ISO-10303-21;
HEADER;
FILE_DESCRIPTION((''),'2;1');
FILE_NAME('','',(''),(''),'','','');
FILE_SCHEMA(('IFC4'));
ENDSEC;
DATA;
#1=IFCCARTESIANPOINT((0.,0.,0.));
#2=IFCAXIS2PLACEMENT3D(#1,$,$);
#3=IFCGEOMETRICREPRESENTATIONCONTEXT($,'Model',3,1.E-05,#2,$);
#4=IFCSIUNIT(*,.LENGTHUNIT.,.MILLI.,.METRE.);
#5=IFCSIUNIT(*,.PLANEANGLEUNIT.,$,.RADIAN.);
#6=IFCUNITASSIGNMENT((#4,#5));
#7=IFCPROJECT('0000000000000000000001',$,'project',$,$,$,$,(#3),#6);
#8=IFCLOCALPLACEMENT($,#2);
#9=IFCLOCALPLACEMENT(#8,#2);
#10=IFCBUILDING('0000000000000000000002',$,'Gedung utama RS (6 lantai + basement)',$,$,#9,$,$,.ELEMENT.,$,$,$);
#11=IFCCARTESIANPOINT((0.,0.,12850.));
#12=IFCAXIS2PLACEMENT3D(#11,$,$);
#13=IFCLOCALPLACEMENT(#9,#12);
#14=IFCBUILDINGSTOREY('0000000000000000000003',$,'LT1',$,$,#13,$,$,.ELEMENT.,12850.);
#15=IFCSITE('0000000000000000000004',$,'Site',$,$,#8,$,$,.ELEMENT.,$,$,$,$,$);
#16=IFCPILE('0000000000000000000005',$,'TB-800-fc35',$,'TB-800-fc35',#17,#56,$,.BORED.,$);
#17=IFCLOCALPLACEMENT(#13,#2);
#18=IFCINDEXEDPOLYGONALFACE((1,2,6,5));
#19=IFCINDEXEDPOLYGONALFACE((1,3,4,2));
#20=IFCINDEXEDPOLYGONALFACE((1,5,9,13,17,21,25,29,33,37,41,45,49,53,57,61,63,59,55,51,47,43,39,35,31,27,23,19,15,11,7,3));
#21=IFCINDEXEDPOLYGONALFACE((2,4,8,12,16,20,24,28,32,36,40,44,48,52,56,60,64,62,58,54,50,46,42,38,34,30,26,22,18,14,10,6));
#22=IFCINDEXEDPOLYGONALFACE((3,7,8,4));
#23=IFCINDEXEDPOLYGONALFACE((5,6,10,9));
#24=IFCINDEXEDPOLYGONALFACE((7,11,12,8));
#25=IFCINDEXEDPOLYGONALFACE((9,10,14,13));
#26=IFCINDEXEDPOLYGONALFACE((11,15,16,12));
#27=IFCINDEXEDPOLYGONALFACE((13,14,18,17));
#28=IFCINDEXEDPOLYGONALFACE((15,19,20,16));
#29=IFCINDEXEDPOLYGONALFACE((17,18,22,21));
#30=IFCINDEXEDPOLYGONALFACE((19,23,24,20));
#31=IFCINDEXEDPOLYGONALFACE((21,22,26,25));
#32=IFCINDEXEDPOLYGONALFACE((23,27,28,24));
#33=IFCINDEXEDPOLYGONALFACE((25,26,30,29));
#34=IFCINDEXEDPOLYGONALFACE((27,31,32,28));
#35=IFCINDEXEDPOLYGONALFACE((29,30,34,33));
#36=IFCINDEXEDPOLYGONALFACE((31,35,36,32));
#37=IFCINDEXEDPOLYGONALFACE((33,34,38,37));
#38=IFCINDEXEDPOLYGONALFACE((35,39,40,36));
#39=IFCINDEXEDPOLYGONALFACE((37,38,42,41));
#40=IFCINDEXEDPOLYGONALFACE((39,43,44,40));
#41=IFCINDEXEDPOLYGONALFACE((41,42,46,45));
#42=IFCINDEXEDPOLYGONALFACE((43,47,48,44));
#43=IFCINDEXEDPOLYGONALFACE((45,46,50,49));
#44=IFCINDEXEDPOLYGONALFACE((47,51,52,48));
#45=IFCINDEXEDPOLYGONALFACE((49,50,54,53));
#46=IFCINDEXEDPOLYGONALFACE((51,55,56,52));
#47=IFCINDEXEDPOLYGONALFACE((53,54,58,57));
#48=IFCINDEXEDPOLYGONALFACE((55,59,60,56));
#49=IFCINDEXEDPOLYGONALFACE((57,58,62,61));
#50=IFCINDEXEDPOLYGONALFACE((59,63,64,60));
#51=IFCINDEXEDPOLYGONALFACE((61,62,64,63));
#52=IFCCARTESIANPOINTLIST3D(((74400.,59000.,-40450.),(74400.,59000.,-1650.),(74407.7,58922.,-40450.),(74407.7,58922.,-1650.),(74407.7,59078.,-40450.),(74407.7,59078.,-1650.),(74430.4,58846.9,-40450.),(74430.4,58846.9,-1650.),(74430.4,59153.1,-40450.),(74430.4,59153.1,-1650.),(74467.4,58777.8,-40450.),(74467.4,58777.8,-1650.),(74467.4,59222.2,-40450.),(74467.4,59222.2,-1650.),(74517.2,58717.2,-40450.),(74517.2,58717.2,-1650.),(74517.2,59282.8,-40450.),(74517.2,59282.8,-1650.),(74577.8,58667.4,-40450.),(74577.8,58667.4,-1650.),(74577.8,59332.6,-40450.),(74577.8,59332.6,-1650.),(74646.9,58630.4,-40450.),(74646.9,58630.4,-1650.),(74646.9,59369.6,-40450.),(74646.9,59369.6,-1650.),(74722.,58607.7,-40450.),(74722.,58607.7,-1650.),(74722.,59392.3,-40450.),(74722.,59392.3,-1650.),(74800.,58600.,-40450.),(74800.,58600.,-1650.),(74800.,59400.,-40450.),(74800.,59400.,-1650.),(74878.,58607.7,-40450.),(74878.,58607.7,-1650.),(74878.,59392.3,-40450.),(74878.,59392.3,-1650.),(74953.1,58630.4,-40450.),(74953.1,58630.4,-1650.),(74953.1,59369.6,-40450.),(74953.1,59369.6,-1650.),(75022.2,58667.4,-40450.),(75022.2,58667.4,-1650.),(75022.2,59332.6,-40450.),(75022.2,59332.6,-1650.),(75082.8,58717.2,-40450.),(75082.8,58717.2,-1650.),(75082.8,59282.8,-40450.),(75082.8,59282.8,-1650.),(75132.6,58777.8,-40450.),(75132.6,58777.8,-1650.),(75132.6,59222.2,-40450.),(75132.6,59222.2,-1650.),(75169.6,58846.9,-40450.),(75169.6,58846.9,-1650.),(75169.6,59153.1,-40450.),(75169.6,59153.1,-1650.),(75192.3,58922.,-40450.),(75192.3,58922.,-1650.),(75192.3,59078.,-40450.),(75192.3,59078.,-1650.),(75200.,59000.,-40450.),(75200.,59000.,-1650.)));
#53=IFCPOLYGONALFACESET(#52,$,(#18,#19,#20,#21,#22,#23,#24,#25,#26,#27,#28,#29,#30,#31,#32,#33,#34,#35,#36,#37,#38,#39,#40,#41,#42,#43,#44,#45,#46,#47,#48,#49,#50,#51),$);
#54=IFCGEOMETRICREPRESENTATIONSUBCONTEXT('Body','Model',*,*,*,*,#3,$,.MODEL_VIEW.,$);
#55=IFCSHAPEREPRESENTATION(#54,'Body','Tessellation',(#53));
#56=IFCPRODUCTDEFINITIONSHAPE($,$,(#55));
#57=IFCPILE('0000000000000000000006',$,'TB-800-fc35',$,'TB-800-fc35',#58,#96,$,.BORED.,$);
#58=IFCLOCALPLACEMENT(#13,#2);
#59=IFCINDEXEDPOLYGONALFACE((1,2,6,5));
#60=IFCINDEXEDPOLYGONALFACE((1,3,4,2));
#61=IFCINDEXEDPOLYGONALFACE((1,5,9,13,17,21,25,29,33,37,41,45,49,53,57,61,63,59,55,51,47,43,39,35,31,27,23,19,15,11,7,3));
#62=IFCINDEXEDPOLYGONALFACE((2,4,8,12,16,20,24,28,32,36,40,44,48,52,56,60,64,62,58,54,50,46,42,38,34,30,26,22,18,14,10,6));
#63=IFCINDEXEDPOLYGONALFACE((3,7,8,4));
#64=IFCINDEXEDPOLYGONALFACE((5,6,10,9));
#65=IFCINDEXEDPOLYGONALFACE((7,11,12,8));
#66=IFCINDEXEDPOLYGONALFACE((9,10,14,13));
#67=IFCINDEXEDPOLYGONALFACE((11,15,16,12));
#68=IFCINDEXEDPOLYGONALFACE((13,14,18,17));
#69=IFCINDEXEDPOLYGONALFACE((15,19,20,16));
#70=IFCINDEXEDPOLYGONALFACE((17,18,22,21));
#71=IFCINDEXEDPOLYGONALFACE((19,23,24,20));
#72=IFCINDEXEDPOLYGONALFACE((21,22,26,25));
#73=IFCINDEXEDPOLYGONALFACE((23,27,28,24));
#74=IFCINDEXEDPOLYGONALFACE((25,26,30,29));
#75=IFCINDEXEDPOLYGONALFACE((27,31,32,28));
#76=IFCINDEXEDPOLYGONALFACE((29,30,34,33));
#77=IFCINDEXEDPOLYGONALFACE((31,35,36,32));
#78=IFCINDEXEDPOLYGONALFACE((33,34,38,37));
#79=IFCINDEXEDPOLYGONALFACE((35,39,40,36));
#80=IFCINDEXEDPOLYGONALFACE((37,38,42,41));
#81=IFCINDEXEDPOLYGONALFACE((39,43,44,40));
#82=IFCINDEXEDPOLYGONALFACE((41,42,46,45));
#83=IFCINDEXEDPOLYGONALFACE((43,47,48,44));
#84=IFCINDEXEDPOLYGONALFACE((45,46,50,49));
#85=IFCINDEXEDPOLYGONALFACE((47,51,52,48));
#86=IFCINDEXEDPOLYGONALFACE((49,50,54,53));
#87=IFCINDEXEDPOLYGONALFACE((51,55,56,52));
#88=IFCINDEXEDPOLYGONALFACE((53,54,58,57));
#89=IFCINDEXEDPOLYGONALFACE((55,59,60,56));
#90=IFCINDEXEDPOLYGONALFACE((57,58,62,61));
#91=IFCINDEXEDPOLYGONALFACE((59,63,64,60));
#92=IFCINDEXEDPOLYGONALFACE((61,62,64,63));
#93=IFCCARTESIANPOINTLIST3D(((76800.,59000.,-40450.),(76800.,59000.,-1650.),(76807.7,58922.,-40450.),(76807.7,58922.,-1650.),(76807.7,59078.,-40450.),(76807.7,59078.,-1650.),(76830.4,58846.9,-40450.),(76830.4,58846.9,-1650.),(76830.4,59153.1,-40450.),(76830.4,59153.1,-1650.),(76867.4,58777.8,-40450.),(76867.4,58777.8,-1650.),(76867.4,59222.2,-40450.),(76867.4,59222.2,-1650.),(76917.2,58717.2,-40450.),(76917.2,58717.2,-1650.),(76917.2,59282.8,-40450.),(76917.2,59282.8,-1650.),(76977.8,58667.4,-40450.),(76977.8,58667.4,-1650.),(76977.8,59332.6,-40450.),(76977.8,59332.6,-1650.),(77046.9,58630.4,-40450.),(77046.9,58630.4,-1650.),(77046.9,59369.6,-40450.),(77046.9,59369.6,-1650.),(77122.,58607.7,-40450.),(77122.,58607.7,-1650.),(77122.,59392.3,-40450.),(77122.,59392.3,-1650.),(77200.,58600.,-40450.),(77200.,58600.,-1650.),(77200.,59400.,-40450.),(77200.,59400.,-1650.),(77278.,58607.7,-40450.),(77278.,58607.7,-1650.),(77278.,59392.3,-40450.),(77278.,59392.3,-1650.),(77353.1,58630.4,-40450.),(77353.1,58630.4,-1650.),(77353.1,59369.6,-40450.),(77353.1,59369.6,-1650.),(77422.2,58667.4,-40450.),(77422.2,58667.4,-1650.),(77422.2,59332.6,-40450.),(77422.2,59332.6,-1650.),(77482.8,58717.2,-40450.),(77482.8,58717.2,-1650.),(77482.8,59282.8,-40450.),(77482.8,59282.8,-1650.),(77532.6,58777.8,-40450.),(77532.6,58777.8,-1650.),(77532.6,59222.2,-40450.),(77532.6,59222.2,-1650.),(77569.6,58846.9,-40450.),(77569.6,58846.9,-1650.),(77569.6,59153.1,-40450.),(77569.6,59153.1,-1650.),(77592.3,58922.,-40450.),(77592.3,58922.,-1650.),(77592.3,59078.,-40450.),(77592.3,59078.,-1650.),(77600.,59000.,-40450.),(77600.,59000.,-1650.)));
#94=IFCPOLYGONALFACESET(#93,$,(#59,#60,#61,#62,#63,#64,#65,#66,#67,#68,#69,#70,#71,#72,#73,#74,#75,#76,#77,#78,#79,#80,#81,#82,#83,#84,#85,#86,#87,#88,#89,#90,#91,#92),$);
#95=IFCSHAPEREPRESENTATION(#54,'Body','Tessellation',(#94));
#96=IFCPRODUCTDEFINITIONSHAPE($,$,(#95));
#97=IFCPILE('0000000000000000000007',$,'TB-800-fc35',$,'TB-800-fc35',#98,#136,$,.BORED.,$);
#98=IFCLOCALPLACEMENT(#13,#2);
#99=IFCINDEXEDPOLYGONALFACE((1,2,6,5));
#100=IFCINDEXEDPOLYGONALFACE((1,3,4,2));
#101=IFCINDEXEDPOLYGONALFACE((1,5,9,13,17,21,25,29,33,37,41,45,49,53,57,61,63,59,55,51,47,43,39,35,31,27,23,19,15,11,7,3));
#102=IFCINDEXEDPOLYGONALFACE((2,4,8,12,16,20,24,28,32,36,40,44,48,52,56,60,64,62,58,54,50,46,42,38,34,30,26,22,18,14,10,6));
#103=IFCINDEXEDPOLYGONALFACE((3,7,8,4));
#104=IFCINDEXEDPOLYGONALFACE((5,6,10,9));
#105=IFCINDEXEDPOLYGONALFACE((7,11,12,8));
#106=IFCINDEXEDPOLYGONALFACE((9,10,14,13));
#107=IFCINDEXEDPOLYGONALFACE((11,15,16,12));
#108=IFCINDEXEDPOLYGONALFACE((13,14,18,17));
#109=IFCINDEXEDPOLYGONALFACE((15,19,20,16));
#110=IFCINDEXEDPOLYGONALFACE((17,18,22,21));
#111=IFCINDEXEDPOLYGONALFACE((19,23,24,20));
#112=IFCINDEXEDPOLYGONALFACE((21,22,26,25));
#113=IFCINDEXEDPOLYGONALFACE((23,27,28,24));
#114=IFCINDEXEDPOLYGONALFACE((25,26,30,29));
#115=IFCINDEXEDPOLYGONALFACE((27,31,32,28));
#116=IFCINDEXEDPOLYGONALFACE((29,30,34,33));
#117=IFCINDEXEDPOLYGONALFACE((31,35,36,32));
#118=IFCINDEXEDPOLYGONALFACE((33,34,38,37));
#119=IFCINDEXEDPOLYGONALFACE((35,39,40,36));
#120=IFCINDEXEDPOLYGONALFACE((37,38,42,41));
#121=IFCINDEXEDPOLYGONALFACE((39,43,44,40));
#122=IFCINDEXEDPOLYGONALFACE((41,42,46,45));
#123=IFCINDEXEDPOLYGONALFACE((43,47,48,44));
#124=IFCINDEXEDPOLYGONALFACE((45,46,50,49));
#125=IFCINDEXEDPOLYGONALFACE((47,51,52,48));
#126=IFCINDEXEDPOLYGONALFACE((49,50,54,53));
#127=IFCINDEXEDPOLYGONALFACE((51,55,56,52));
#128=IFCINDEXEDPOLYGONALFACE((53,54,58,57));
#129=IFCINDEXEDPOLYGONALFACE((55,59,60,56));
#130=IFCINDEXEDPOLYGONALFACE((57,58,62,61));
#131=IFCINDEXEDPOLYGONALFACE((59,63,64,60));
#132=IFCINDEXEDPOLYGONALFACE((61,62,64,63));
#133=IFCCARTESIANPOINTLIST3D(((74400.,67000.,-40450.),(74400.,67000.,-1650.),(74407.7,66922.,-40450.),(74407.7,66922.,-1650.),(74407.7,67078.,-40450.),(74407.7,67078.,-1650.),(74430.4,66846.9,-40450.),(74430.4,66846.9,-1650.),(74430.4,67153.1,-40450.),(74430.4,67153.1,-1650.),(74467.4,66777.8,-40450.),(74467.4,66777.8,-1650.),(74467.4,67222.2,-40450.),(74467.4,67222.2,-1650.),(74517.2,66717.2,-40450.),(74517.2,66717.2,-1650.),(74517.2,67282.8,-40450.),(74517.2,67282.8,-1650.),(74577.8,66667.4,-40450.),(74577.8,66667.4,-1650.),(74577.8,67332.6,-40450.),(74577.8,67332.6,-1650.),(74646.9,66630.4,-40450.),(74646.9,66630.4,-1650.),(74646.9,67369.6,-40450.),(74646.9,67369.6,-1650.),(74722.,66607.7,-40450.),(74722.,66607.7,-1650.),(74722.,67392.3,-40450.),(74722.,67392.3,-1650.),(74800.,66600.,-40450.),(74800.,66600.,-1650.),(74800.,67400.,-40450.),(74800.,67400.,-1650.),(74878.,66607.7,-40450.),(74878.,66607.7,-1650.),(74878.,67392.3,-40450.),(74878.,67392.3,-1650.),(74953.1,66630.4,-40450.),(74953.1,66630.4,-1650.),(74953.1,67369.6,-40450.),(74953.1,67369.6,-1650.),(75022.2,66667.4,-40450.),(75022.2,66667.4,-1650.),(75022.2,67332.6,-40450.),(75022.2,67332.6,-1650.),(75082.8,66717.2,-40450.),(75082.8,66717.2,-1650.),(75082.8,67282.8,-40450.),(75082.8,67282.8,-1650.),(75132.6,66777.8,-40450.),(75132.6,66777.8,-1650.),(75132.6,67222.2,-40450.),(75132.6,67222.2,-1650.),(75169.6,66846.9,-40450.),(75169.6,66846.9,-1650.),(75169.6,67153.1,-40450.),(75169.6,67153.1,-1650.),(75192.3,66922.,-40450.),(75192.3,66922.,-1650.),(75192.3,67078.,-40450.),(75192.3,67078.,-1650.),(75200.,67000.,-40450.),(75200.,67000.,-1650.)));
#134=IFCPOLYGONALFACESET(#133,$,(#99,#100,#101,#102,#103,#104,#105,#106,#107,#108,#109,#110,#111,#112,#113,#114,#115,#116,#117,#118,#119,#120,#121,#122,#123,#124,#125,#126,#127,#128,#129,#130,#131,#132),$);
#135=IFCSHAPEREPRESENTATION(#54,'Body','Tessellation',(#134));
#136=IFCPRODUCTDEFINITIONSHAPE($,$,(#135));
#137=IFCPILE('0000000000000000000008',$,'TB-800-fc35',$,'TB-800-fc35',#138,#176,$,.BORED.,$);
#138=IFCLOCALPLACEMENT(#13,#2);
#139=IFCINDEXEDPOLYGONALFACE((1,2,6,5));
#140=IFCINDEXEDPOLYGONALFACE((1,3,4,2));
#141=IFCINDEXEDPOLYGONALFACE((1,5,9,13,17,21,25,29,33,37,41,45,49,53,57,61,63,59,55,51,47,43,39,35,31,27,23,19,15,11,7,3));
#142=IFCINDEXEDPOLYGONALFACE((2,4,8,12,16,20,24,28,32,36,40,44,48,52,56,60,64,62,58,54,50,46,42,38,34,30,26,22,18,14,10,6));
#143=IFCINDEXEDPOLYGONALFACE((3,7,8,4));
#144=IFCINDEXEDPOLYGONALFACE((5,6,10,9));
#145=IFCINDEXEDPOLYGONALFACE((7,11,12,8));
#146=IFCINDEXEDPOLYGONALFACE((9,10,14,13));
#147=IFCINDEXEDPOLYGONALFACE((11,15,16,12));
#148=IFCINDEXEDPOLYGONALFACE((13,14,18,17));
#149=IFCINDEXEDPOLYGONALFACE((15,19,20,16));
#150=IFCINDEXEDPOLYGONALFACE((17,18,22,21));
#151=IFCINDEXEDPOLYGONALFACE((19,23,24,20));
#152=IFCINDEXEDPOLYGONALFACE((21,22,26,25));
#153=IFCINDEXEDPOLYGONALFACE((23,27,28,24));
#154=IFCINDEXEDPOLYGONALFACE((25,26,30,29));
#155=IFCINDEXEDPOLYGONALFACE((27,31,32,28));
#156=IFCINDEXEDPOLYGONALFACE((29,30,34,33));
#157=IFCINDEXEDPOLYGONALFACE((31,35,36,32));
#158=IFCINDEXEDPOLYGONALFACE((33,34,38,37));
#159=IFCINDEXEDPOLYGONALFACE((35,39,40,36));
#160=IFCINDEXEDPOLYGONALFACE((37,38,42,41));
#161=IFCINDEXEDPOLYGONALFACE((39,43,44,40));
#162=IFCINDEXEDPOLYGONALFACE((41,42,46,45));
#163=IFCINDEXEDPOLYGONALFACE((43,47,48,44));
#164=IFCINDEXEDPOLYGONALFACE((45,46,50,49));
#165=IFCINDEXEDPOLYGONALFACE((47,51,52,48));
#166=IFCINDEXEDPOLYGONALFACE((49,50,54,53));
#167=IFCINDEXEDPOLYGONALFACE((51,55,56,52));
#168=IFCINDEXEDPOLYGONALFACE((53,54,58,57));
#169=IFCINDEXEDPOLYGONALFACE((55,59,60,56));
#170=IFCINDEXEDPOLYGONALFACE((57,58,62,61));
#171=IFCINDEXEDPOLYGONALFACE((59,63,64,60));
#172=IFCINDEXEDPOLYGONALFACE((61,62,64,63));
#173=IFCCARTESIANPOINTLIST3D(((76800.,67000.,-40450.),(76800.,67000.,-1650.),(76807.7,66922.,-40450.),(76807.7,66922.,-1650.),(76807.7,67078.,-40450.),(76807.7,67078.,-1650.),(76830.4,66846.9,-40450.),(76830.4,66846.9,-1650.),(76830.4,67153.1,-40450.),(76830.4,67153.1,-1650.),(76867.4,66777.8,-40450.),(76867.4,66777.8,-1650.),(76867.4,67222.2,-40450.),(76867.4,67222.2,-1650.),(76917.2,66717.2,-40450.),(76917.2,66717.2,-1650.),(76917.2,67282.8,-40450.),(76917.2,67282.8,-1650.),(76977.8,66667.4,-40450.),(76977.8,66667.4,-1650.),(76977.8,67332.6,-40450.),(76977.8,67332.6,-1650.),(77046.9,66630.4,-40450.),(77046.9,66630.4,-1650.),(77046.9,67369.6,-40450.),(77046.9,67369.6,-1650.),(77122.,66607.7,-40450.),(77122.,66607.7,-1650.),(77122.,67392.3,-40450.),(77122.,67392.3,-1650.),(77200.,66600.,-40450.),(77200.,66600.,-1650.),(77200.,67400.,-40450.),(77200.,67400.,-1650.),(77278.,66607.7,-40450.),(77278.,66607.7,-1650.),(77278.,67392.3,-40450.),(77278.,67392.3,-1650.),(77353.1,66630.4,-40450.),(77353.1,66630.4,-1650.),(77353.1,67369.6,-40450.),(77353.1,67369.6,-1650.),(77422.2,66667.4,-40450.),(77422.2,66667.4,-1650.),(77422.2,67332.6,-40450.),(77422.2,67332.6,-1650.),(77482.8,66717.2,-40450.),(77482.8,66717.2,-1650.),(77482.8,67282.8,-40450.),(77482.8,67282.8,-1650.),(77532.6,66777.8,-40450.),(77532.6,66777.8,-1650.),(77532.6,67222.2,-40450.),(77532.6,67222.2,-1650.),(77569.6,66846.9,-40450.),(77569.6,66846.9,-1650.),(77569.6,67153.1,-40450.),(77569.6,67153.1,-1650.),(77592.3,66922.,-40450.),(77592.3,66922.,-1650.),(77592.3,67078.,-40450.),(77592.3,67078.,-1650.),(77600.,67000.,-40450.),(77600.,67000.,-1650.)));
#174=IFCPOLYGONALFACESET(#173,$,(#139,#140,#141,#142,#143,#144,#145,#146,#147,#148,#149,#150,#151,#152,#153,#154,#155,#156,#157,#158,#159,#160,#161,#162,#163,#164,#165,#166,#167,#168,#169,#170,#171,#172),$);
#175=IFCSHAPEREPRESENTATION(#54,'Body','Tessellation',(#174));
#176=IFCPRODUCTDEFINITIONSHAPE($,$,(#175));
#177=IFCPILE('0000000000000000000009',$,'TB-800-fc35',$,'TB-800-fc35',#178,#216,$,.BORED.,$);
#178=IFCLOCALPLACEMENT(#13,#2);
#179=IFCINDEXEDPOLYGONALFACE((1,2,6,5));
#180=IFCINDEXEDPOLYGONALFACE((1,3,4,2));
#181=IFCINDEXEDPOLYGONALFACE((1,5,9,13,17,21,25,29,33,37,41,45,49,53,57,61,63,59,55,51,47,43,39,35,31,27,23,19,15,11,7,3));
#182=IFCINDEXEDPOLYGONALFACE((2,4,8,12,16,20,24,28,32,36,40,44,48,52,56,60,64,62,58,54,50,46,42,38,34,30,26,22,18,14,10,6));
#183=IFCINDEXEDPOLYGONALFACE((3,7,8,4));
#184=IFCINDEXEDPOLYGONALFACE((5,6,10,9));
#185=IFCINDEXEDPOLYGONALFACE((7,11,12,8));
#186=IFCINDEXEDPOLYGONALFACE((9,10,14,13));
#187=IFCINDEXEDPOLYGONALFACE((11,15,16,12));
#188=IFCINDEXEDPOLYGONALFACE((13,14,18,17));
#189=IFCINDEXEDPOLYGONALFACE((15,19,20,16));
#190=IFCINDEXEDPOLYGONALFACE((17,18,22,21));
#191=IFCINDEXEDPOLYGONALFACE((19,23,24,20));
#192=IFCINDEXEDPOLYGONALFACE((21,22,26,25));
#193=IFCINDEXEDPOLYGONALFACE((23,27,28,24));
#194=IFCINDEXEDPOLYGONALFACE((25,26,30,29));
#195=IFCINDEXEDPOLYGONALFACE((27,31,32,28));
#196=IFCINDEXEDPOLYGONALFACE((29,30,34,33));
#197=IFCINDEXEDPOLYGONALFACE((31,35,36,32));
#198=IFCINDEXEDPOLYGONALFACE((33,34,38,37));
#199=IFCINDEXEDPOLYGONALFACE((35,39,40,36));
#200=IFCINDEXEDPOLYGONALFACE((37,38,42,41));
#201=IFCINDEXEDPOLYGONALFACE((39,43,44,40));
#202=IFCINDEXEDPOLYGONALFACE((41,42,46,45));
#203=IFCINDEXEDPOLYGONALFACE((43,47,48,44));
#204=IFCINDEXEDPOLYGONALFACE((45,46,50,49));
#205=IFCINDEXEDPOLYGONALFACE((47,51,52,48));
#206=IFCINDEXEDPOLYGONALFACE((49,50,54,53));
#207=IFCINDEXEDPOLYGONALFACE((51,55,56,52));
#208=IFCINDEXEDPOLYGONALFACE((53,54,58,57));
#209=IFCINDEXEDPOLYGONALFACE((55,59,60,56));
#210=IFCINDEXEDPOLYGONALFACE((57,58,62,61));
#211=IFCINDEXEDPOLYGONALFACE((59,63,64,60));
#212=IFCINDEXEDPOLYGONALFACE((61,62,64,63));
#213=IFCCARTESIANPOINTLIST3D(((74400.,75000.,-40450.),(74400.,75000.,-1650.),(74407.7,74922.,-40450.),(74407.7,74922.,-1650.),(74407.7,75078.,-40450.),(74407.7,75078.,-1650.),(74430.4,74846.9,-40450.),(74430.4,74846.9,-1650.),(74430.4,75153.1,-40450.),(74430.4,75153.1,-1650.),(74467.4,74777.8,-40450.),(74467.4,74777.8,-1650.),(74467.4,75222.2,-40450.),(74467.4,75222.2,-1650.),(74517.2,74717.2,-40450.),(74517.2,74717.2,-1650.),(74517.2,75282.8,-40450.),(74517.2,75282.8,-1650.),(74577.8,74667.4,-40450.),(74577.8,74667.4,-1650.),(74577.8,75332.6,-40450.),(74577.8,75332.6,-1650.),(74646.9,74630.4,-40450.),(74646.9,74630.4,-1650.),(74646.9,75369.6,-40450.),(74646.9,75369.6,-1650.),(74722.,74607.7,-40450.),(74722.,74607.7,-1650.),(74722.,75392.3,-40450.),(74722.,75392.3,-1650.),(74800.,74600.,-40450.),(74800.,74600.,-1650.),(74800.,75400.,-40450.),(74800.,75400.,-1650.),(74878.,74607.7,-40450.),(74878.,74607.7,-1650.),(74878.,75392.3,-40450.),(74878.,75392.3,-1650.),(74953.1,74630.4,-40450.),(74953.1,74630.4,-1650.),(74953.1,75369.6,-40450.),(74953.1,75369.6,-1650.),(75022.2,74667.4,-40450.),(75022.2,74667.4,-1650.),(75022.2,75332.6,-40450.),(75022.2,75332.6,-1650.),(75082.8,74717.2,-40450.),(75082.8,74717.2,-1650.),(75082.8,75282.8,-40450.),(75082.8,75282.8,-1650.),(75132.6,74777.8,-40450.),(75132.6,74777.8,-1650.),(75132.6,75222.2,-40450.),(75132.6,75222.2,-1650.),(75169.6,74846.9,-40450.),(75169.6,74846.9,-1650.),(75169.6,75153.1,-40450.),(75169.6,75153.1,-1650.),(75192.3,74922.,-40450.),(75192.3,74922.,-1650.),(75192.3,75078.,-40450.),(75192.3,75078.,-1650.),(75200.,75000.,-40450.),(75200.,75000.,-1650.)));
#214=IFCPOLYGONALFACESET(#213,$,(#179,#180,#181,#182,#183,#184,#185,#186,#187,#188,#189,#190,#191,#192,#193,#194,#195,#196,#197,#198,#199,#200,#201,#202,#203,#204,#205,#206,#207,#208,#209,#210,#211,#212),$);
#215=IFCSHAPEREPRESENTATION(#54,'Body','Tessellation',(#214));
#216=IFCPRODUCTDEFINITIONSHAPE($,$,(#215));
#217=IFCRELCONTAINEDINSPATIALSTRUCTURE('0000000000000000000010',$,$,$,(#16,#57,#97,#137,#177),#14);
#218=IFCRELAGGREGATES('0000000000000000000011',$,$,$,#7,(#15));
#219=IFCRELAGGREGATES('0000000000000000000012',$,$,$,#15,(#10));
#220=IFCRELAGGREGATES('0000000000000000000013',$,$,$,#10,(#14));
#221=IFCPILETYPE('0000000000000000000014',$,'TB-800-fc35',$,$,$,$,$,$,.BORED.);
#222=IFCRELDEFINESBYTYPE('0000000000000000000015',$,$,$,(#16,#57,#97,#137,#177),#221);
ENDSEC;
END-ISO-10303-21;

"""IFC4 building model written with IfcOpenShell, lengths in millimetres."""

from ifc_helpers import new_model, si_unit, frame, origin, origin_2d, place, context, subcontext, project, spatial, circle, extrude, material_profile, profile_set, profile_usage, type_object, element, save


model = new_model("IFC4")

# Units and contexts
model_context = context("Model", 3, precision=1e-05, world=origin())
body_context = subcontext(model_context, "Body", "Model", "MODEL_VIEW")
ifc_project = project(units=[si_unit("LENGTHUNIT", "METRE", prefix="MILLI"), si_unit("PLANEANGLEUNIT", "RADIAN")], contexts=[model_context])

# Site, building, storey
site_placement = place(None, origin())
site = spatial("IfcSite", under=ifc_project, at=site_placement, Name="Site", CompositionType="ELEMENT")
building_placement = place(site_placement, origin())
building = spatial("IfcBuilding", under=site, at=building_placement, Name="Gedung utama RS (6 lantai + basement)", CompositionType="ELEMENT")
storey_placement = place(building_placement, frame((0.0, 0.0, 12850.0)))
storey = spatial("IfcBuildingStorey", under=building, at=storey_placement, Name="LT1", CompositionType="ELEMENT", Elevation=12850.0)

# Piles
ifc_material_profile_1 = material_profile(None, circle(Radius=400.0, at=origin_2d()), Name="TB-800-fc35")
ifc_profile_set_1 = profile_set([ifc_material_profile_1], Name="TB-800-fc35")
ifc_profile_usage_1 = profile_usage(ifc_profile_set_1, cardinal=5)
pile_type = type_object("IfcPileType", Name="TB-800-fc35", PredefinedType="BORED")
for number, where, z_axis, x_axis, name in (
    (1, (74800.0, 59000.0, -40450.0), (0.0, 0.0, 1.0), (1.0, 0.0, 0.0), "TB-800-fc35"),
    (2, (77200.0, 59000.0, -40450.0), (0.0, 0.0, 1.0), (1.0, 0.0, 0.0), "TB-800-fc35"),
    (3, (74800.0, 67000.0, -40450.0), (0.0, 0.0, 1.0), (1.0, 0.0, 0.0), "TB-800-fc35"),
    (4, (77200.0, 67000.0, -40450.0), (0.0, 0.0, 1.0), (1.0, 0.0, 0.0), "TB-800-fc35"),
    (5, (74800.0, 75000.0, -40450.0), (0.0, 0.0, 1.0), (1.0, 0.0, 0.0), "TB-800-fc35"),
):
    element("IfcPile", number, at=place(storey_placement, frame(where, z_axis=z_axis, x_axis=x_axis)), inside=storey, type_object=pile_type, material=ifc_profile_usage_1, Name=name, ObjectType="TB-800-fc35", PredefinedType="BORED", context=body_context, shape_type="SweptSolid", body=[
        extrude(circle(Radius=400.0, at=origin_2d()), origin(), (0.0, 0.0, 1.0), 38800.0),
    ])

save(model, "model.ifc")
